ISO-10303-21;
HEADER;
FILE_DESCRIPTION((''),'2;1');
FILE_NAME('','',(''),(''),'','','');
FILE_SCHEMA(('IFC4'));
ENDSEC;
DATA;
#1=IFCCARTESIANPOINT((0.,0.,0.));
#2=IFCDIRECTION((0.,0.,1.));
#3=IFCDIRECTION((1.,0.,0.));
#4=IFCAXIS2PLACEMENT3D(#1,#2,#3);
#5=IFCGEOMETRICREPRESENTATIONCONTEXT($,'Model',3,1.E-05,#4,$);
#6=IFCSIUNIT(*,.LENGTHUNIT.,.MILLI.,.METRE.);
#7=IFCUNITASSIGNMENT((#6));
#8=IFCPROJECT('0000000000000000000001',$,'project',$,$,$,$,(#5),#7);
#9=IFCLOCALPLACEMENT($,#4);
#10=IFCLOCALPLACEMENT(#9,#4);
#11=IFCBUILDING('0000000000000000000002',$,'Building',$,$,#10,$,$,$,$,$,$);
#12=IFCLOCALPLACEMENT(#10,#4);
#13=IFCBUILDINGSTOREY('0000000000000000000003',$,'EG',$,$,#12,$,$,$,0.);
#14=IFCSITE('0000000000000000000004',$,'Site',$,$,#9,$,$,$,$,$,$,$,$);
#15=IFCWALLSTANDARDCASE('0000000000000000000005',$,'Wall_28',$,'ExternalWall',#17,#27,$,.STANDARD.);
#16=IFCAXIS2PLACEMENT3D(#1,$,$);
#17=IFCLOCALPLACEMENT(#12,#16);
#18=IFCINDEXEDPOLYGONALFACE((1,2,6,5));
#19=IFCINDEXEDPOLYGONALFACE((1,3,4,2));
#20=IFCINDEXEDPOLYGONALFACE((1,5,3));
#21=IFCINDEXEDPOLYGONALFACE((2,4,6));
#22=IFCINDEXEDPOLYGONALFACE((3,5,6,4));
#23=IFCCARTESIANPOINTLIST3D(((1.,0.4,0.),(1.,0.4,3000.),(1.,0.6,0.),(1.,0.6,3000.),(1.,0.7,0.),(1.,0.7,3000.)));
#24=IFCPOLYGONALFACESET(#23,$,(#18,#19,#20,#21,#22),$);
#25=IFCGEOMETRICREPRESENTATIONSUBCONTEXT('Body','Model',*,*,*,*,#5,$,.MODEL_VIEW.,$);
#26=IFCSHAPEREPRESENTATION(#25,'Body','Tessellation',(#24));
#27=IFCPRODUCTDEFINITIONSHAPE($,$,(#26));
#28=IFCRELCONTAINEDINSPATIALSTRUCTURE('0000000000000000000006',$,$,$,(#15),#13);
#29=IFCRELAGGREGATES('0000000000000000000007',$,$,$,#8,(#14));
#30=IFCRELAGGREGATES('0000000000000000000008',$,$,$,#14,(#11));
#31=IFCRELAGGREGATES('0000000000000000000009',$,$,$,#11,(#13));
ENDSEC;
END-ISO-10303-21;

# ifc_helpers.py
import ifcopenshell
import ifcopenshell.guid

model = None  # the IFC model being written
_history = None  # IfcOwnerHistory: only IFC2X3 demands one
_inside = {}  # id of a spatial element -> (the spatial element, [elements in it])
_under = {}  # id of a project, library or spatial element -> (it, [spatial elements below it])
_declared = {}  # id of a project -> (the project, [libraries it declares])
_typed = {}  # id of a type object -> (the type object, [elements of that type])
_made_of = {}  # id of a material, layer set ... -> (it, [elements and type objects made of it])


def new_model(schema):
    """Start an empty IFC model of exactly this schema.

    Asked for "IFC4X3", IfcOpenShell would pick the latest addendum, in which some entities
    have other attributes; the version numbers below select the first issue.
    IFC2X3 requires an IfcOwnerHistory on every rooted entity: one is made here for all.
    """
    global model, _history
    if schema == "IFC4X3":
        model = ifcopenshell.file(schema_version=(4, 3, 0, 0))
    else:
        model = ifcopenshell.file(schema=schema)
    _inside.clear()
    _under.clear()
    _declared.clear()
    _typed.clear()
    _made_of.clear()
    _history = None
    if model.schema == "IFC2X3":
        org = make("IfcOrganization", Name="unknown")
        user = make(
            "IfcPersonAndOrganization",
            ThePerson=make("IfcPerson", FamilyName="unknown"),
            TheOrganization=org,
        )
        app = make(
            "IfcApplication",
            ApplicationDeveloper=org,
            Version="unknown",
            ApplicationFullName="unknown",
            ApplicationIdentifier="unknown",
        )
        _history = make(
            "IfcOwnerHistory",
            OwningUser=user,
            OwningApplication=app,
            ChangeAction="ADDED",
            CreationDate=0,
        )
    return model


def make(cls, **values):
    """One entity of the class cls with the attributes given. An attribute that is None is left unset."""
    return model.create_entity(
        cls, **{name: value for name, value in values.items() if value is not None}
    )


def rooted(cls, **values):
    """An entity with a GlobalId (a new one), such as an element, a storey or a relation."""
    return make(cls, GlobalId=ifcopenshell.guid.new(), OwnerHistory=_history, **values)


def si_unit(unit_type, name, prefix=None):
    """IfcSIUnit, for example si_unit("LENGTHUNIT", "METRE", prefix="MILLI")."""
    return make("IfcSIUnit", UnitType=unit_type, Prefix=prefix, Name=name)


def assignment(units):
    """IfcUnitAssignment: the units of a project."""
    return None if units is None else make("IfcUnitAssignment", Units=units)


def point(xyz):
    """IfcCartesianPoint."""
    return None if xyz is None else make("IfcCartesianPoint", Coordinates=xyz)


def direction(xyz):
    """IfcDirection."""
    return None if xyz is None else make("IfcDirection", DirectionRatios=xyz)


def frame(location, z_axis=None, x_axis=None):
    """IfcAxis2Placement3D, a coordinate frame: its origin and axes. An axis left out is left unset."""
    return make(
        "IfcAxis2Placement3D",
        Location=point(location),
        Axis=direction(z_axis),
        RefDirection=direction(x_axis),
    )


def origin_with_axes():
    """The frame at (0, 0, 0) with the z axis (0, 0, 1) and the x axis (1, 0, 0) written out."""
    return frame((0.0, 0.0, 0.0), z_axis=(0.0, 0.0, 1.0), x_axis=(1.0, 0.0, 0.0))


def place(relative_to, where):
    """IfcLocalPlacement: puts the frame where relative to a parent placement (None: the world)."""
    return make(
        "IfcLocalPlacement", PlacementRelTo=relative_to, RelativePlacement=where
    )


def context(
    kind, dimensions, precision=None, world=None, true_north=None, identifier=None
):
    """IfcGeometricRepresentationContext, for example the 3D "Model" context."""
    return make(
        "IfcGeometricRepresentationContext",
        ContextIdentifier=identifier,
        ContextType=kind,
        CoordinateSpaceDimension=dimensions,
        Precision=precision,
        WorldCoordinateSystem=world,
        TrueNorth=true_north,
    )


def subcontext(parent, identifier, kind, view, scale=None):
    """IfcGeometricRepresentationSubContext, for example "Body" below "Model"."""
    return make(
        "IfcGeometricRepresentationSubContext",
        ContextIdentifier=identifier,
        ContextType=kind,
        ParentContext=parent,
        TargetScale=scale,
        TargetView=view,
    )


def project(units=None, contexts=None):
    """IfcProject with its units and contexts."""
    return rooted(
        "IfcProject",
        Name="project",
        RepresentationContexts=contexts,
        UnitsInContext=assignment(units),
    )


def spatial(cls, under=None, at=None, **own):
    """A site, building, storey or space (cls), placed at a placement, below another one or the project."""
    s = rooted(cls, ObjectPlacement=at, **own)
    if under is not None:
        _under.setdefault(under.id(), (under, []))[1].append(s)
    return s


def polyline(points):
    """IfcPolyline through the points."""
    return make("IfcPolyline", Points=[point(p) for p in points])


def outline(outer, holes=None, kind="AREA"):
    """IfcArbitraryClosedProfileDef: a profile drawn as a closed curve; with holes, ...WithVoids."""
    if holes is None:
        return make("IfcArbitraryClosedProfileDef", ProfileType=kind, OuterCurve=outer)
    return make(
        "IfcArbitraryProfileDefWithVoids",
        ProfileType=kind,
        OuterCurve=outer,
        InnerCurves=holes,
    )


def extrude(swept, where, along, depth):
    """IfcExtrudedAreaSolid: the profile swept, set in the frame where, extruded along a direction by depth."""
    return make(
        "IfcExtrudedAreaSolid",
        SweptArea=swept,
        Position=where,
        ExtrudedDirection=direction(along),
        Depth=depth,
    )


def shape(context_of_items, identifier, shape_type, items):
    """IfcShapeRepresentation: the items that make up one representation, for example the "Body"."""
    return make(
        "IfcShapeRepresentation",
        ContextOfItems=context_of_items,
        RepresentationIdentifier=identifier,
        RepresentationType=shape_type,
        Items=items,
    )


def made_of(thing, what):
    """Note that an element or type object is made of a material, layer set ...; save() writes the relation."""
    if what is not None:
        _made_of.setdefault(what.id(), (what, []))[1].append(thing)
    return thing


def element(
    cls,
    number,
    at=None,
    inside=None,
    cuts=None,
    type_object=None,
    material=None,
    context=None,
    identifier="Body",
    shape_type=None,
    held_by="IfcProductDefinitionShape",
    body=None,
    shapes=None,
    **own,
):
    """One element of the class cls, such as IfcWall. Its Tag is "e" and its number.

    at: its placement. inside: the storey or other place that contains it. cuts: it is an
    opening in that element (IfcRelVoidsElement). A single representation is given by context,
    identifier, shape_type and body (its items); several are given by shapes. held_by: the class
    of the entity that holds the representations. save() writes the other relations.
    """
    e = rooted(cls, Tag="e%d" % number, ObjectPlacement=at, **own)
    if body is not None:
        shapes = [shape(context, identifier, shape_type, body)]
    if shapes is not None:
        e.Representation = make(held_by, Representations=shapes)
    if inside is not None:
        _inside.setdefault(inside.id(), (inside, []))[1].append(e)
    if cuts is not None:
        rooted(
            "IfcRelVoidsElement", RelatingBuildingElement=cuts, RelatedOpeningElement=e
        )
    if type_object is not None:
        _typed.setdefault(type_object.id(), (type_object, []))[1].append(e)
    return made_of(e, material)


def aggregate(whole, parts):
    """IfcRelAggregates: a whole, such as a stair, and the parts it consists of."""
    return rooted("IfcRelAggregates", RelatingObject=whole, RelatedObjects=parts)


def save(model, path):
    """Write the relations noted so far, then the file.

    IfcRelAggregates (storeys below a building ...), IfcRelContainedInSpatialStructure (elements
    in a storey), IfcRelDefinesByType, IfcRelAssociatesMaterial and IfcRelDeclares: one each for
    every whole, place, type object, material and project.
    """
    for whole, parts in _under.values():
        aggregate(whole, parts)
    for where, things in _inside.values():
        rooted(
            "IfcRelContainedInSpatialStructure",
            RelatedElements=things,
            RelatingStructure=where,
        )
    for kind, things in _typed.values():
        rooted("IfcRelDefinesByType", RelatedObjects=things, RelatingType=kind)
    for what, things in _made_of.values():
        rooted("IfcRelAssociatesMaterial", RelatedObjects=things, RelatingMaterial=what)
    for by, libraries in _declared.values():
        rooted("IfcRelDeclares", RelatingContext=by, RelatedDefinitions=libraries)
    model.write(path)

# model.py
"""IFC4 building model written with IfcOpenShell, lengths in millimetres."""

from ifc_helpers import new_model, si_unit, origin_with_axes, place, context, subcontext, project, spatial, polyline, outline, extrude, element, save


model = new_model("IFC4")

# Units and contexts
model_context = context("Model", 3, precision=1e-05, world=origin_with_axes())
body_context = subcontext(model_context, "Body", "Model", "MODEL_VIEW")
ifc_project = project(units=[si_unit("LENGTHUNIT", "METRE", prefix="MILLI")], contexts=[model_context])

# Site, building, storey
site_placement = place(None, origin_with_axes())
site = spatial("IfcSite", under=ifc_project, at=site_placement, Name="Site")
building_placement = place(site_placement, origin_with_axes())
building = spatial("IfcBuilding", under=site, at=building_placement, Name="Building")
storey_placement = place(building_placement, origin_with_axes())
storey = spatial("IfcBuildingStorey", under=building, at=storey_placement, Name="EG", Elevation=0.0)

# Wall
wall_1_placement = place(storey_placement, origin_with_axes())
element("IfcWallStandardCase", 1, at=wall_1_placement, inside=storey, Name="Wall_28", ObjectType="ExternalWall", PredefinedType="STANDARD", context=body_context, shape_type="SweptSolid", body=[
    extrude(outline(polyline([(1.0, 0.4, 0.0), (1.0, 0.7, 0.0), (1.0, 0.7, 0.0), (1.0, 0.7, 0.0), (1.0, 0.7, 0.0), (1.0, 0.7, 0.0), (1.0, 0.7, 0.0), (1.0, 0.7, 0.0), (1.0, 0.6, 0.0), (1.0, 0.6, 0.0), (1.0, 0.4, 0.0), (1.0, 0.4, 0.0)])), origin_with_axes(), (0.0, 0.0, 1.0), 3000.0),
])

save(model, "model.ifc")
